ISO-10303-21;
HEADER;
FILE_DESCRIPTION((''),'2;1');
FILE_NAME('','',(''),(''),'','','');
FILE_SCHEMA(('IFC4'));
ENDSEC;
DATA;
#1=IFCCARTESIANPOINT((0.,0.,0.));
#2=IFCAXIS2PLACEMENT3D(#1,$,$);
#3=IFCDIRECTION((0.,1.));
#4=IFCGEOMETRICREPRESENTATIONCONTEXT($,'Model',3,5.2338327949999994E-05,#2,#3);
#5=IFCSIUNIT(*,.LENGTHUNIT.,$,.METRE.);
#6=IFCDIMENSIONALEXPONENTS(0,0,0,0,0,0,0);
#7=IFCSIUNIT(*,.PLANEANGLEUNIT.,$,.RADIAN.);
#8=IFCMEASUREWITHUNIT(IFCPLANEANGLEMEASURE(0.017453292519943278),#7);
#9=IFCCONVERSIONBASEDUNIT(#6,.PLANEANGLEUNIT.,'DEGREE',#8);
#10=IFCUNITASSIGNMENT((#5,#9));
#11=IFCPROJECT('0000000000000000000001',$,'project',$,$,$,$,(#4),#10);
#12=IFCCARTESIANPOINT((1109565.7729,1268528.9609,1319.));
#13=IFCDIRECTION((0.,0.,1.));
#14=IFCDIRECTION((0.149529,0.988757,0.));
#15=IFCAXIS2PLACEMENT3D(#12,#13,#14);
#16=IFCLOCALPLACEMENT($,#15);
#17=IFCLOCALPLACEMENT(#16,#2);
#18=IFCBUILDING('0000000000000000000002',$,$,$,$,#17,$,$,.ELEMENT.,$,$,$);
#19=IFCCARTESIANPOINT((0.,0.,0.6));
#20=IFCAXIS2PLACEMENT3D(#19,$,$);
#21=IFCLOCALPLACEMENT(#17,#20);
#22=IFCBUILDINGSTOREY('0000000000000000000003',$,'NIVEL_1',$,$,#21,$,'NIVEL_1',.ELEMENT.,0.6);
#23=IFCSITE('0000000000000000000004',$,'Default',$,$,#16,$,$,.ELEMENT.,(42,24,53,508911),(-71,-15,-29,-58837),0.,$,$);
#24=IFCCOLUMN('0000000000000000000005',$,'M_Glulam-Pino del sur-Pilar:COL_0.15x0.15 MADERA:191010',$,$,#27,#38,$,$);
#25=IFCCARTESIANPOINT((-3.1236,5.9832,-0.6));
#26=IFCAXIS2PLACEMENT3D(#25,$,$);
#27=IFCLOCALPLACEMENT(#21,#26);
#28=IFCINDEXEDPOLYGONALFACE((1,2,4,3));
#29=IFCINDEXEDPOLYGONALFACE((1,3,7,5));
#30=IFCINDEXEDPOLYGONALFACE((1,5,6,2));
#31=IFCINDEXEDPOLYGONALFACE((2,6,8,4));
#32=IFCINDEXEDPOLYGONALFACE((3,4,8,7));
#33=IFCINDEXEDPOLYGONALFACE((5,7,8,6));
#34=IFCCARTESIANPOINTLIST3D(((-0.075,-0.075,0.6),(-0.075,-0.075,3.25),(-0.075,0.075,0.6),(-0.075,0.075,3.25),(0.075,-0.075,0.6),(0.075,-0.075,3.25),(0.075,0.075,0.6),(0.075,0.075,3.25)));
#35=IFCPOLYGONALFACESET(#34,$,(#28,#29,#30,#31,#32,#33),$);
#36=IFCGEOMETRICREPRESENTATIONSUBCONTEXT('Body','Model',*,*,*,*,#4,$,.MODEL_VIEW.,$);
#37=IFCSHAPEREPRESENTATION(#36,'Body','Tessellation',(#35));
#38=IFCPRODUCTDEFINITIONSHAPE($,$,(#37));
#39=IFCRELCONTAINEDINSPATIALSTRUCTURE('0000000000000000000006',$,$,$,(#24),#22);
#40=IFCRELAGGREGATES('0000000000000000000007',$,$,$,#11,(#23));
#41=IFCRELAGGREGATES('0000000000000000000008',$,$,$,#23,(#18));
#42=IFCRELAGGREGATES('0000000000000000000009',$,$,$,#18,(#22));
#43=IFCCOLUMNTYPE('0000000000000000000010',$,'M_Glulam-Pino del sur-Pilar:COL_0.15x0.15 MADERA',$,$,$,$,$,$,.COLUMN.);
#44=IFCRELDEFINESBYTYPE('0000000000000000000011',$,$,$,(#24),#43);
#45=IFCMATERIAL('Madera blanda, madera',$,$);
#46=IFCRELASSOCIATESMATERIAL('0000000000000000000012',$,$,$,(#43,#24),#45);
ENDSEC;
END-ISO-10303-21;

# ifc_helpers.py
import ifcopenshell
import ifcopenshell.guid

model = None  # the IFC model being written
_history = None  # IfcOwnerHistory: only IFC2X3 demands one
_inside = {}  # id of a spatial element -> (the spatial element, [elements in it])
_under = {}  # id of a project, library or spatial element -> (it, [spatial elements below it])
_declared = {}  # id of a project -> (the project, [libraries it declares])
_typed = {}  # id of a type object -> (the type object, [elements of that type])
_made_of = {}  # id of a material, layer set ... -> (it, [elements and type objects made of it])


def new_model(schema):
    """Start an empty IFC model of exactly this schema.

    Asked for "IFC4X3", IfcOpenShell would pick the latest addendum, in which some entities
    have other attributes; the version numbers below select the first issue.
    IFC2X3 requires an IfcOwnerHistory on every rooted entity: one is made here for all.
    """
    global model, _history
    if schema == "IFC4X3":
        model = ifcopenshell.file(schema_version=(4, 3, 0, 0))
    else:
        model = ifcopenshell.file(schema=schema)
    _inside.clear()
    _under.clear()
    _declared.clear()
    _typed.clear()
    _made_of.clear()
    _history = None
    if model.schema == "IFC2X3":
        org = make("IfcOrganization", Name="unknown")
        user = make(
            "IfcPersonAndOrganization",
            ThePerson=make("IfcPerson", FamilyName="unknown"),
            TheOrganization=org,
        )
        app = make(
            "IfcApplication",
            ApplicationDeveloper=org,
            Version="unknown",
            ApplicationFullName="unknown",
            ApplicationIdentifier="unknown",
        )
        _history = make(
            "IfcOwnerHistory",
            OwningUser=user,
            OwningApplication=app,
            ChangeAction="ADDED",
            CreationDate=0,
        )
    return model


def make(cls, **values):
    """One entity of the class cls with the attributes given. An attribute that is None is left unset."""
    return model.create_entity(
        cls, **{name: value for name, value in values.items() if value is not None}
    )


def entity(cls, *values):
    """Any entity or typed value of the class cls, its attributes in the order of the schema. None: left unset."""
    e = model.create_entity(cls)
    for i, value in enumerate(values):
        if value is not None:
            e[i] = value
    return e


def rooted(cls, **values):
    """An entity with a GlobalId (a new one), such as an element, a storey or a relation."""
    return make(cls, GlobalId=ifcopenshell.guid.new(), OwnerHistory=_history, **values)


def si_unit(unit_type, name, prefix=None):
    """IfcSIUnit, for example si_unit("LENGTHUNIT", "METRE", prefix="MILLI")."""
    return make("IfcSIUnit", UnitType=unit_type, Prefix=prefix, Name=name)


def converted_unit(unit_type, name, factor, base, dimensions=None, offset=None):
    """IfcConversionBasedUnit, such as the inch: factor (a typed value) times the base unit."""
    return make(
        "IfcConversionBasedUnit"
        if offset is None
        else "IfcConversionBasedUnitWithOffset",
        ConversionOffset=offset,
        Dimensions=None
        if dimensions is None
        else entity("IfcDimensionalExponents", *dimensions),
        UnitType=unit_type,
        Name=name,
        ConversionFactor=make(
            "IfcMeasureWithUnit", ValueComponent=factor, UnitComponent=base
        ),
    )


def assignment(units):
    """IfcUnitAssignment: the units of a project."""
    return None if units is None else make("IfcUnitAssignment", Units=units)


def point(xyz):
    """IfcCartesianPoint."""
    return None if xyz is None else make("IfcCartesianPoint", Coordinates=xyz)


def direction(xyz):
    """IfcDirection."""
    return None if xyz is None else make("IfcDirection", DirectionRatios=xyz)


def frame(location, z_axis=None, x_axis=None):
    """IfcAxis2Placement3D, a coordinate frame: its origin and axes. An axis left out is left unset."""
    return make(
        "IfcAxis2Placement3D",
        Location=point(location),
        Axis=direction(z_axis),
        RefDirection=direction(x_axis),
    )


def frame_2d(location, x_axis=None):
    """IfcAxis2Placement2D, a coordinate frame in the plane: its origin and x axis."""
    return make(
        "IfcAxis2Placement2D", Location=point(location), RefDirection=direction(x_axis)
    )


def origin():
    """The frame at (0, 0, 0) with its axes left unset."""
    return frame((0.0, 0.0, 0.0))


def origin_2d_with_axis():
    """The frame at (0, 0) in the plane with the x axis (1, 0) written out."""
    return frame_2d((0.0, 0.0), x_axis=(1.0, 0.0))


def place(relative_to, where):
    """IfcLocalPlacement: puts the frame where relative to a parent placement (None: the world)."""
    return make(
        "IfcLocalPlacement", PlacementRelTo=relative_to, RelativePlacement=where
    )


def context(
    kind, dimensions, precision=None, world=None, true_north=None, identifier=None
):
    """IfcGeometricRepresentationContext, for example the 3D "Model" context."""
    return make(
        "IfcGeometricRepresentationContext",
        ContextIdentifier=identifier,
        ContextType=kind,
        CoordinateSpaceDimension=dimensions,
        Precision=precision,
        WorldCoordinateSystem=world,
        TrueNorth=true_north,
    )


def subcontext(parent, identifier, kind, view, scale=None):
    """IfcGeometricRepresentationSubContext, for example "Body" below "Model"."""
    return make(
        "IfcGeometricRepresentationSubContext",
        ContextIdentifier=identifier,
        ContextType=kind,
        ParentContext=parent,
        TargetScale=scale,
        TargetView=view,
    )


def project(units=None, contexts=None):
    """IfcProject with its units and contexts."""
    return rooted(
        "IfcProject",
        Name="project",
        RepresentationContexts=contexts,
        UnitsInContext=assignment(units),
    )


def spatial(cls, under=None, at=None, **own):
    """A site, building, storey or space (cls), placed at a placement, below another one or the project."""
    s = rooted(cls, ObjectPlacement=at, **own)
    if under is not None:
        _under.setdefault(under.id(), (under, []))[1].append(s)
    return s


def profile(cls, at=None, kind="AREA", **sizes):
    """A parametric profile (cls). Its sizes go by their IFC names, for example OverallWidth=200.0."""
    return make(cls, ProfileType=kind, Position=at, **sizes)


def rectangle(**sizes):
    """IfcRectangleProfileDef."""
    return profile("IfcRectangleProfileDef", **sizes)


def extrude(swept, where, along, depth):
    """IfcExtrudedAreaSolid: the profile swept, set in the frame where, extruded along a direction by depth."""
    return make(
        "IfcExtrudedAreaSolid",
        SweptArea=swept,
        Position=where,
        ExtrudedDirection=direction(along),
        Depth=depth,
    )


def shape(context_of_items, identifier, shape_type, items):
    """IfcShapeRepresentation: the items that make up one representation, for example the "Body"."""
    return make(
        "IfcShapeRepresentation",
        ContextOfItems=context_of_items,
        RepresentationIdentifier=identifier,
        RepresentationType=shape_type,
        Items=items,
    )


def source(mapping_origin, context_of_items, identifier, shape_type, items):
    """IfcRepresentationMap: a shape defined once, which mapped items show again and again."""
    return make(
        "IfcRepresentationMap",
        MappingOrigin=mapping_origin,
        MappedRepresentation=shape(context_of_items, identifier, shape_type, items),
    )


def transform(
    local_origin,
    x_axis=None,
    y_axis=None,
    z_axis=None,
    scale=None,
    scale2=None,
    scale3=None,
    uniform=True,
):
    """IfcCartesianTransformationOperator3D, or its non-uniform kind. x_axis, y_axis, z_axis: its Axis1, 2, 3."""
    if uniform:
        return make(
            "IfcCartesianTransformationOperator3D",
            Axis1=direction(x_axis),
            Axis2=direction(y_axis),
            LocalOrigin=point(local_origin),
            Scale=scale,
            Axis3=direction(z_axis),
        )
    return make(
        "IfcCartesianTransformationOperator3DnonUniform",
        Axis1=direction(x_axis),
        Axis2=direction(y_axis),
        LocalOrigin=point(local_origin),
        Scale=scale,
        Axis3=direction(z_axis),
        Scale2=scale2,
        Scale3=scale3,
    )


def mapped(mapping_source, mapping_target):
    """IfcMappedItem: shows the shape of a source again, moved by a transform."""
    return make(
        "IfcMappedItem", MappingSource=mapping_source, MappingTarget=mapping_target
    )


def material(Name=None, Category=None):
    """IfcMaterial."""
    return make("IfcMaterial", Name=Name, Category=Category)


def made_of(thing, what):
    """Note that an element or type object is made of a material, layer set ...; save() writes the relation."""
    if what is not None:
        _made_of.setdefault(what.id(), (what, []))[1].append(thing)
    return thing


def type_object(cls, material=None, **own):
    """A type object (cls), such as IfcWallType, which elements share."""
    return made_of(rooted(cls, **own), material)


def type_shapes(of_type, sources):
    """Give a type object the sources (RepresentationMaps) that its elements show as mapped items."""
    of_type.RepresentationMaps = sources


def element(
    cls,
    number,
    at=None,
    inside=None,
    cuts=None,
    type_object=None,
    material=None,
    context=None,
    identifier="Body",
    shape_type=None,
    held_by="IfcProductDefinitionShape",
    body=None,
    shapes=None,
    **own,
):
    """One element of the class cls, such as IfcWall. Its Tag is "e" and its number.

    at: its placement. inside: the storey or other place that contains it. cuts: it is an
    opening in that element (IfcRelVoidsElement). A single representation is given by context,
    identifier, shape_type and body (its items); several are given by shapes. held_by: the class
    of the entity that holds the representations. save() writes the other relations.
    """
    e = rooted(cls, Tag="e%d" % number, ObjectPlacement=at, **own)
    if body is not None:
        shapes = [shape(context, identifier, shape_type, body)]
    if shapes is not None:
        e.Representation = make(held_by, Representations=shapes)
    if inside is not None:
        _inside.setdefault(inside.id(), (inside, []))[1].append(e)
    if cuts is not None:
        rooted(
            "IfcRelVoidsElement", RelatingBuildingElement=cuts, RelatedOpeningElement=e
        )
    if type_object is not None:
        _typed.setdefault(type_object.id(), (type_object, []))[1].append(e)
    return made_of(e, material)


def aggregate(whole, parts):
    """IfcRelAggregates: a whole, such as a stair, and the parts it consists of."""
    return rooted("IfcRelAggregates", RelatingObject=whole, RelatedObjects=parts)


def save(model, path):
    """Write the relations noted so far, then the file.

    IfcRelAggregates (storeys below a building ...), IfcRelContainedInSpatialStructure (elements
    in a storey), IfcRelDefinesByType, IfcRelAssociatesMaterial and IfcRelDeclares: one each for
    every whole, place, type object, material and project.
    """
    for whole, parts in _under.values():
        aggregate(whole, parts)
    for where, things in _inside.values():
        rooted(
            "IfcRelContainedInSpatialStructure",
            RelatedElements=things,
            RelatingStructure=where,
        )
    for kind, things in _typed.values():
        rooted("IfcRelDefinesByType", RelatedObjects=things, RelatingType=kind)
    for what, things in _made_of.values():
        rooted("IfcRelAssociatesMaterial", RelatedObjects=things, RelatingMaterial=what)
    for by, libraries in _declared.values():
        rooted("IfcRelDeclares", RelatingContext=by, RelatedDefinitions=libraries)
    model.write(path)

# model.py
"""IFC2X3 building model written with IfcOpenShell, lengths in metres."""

from ifc_helpers import new_model, entity, si_unit, converted_unit, direction, frame, origin, origin_2d_with_axis, place, context, subcontext, project, spatial, rectangle, extrude, source, transform, mapped, material, type_object, type_shapes, element, save


model = new_model("IFC2X3")

# Units and contexts
model_context = context("Model", 3, precision=5.2338327949999994e-05, world=origin(), true_north=direction((0.0, 1.0)))
body_context = subcontext(model_context, "Body", "Model", "MODEL_VIEW")
ifc_project = project(units=[si_unit("LENGTHUNIT", "METRE"), converted_unit("PLANEANGLEUNIT", "DEGREE", entity("IfcPlaneAngleMeasure", 0.017453292519943278), si_unit("PLANEANGLEUNIT", "RADIAN"), dimensions=[0, 0, 0, 0, 0, 0, 0])], contexts=[model_context])

# Site, building, storey
site_placement = place(None, frame((1109565.7729, 1268528.9609, 1319.0), z_axis=(0.0, 0.0, 1.0), x_axis=(0.149529, 0.988757, 0.0)))
site = spatial("IfcSite", under=ifc_project, at=site_placement, Name="Default", CompositionType="ELEMENT", RefLatitude=(42, 24, 53, 508911), RefLongitude=(-71, -15, -29, -58837), RefElevation=0.0)
building_placement = place(site_placement, origin())
building = spatial("IfcBuilding", under=site, at=building_placement, CompositionType="ELEMENT")
storey_placement = place(building_placement, frame((0.0, 0.0, 0.6)))
storey = spatial("IfcBuildingStorey", under=building, at=storey_placement, Name="NIVEL_1", LongName="NIVEL_1", CompositionType="ELEMENT", Elevation=0.6)

# Column
ifc_material_1 = material(Name="Madera blanda, madera")
column_type = type_object("IfcColumnType", Name="M_Glulam-Pino del sur-Pilar:COL_0.15x0.15 MADERA", PredefinedType="COLUMN", material=ifc_material_1)
shared_shape_1 = source(origin(), body_context, "Body", "SweptSolid", [
    extrude(rectangle(XDim=0.15, YDim=0.15, at=origin_2d_with_axis()), frame((0.0, 0.0, 0.6), z_axis=(0.0, 0.0, 1.0), x_axis=(-1.0, 0.0, 0.0)), (0.0, 0.0, 1.0), 2.65),
])
type_shapes(column_type, [shared_shape_1])
column_placement = place(storey_placement, frame((-3.1236, 5.9832, -0.6)))
element("IfcColumn", 1, at=column_placement, inside=storey, type_object=column_type, material=ifc_material_1, Name="M_Glulam-Pino del sur-Pilar:COL_0.15x0.15 MADERA:191010", context=body_context, shape_type="MappedRepresentation", body=[
    mapped(shared_shape_1, transform((0.0, 0.0, 0.0), scale=1.0)),
])

save(model, "model.ifc")
